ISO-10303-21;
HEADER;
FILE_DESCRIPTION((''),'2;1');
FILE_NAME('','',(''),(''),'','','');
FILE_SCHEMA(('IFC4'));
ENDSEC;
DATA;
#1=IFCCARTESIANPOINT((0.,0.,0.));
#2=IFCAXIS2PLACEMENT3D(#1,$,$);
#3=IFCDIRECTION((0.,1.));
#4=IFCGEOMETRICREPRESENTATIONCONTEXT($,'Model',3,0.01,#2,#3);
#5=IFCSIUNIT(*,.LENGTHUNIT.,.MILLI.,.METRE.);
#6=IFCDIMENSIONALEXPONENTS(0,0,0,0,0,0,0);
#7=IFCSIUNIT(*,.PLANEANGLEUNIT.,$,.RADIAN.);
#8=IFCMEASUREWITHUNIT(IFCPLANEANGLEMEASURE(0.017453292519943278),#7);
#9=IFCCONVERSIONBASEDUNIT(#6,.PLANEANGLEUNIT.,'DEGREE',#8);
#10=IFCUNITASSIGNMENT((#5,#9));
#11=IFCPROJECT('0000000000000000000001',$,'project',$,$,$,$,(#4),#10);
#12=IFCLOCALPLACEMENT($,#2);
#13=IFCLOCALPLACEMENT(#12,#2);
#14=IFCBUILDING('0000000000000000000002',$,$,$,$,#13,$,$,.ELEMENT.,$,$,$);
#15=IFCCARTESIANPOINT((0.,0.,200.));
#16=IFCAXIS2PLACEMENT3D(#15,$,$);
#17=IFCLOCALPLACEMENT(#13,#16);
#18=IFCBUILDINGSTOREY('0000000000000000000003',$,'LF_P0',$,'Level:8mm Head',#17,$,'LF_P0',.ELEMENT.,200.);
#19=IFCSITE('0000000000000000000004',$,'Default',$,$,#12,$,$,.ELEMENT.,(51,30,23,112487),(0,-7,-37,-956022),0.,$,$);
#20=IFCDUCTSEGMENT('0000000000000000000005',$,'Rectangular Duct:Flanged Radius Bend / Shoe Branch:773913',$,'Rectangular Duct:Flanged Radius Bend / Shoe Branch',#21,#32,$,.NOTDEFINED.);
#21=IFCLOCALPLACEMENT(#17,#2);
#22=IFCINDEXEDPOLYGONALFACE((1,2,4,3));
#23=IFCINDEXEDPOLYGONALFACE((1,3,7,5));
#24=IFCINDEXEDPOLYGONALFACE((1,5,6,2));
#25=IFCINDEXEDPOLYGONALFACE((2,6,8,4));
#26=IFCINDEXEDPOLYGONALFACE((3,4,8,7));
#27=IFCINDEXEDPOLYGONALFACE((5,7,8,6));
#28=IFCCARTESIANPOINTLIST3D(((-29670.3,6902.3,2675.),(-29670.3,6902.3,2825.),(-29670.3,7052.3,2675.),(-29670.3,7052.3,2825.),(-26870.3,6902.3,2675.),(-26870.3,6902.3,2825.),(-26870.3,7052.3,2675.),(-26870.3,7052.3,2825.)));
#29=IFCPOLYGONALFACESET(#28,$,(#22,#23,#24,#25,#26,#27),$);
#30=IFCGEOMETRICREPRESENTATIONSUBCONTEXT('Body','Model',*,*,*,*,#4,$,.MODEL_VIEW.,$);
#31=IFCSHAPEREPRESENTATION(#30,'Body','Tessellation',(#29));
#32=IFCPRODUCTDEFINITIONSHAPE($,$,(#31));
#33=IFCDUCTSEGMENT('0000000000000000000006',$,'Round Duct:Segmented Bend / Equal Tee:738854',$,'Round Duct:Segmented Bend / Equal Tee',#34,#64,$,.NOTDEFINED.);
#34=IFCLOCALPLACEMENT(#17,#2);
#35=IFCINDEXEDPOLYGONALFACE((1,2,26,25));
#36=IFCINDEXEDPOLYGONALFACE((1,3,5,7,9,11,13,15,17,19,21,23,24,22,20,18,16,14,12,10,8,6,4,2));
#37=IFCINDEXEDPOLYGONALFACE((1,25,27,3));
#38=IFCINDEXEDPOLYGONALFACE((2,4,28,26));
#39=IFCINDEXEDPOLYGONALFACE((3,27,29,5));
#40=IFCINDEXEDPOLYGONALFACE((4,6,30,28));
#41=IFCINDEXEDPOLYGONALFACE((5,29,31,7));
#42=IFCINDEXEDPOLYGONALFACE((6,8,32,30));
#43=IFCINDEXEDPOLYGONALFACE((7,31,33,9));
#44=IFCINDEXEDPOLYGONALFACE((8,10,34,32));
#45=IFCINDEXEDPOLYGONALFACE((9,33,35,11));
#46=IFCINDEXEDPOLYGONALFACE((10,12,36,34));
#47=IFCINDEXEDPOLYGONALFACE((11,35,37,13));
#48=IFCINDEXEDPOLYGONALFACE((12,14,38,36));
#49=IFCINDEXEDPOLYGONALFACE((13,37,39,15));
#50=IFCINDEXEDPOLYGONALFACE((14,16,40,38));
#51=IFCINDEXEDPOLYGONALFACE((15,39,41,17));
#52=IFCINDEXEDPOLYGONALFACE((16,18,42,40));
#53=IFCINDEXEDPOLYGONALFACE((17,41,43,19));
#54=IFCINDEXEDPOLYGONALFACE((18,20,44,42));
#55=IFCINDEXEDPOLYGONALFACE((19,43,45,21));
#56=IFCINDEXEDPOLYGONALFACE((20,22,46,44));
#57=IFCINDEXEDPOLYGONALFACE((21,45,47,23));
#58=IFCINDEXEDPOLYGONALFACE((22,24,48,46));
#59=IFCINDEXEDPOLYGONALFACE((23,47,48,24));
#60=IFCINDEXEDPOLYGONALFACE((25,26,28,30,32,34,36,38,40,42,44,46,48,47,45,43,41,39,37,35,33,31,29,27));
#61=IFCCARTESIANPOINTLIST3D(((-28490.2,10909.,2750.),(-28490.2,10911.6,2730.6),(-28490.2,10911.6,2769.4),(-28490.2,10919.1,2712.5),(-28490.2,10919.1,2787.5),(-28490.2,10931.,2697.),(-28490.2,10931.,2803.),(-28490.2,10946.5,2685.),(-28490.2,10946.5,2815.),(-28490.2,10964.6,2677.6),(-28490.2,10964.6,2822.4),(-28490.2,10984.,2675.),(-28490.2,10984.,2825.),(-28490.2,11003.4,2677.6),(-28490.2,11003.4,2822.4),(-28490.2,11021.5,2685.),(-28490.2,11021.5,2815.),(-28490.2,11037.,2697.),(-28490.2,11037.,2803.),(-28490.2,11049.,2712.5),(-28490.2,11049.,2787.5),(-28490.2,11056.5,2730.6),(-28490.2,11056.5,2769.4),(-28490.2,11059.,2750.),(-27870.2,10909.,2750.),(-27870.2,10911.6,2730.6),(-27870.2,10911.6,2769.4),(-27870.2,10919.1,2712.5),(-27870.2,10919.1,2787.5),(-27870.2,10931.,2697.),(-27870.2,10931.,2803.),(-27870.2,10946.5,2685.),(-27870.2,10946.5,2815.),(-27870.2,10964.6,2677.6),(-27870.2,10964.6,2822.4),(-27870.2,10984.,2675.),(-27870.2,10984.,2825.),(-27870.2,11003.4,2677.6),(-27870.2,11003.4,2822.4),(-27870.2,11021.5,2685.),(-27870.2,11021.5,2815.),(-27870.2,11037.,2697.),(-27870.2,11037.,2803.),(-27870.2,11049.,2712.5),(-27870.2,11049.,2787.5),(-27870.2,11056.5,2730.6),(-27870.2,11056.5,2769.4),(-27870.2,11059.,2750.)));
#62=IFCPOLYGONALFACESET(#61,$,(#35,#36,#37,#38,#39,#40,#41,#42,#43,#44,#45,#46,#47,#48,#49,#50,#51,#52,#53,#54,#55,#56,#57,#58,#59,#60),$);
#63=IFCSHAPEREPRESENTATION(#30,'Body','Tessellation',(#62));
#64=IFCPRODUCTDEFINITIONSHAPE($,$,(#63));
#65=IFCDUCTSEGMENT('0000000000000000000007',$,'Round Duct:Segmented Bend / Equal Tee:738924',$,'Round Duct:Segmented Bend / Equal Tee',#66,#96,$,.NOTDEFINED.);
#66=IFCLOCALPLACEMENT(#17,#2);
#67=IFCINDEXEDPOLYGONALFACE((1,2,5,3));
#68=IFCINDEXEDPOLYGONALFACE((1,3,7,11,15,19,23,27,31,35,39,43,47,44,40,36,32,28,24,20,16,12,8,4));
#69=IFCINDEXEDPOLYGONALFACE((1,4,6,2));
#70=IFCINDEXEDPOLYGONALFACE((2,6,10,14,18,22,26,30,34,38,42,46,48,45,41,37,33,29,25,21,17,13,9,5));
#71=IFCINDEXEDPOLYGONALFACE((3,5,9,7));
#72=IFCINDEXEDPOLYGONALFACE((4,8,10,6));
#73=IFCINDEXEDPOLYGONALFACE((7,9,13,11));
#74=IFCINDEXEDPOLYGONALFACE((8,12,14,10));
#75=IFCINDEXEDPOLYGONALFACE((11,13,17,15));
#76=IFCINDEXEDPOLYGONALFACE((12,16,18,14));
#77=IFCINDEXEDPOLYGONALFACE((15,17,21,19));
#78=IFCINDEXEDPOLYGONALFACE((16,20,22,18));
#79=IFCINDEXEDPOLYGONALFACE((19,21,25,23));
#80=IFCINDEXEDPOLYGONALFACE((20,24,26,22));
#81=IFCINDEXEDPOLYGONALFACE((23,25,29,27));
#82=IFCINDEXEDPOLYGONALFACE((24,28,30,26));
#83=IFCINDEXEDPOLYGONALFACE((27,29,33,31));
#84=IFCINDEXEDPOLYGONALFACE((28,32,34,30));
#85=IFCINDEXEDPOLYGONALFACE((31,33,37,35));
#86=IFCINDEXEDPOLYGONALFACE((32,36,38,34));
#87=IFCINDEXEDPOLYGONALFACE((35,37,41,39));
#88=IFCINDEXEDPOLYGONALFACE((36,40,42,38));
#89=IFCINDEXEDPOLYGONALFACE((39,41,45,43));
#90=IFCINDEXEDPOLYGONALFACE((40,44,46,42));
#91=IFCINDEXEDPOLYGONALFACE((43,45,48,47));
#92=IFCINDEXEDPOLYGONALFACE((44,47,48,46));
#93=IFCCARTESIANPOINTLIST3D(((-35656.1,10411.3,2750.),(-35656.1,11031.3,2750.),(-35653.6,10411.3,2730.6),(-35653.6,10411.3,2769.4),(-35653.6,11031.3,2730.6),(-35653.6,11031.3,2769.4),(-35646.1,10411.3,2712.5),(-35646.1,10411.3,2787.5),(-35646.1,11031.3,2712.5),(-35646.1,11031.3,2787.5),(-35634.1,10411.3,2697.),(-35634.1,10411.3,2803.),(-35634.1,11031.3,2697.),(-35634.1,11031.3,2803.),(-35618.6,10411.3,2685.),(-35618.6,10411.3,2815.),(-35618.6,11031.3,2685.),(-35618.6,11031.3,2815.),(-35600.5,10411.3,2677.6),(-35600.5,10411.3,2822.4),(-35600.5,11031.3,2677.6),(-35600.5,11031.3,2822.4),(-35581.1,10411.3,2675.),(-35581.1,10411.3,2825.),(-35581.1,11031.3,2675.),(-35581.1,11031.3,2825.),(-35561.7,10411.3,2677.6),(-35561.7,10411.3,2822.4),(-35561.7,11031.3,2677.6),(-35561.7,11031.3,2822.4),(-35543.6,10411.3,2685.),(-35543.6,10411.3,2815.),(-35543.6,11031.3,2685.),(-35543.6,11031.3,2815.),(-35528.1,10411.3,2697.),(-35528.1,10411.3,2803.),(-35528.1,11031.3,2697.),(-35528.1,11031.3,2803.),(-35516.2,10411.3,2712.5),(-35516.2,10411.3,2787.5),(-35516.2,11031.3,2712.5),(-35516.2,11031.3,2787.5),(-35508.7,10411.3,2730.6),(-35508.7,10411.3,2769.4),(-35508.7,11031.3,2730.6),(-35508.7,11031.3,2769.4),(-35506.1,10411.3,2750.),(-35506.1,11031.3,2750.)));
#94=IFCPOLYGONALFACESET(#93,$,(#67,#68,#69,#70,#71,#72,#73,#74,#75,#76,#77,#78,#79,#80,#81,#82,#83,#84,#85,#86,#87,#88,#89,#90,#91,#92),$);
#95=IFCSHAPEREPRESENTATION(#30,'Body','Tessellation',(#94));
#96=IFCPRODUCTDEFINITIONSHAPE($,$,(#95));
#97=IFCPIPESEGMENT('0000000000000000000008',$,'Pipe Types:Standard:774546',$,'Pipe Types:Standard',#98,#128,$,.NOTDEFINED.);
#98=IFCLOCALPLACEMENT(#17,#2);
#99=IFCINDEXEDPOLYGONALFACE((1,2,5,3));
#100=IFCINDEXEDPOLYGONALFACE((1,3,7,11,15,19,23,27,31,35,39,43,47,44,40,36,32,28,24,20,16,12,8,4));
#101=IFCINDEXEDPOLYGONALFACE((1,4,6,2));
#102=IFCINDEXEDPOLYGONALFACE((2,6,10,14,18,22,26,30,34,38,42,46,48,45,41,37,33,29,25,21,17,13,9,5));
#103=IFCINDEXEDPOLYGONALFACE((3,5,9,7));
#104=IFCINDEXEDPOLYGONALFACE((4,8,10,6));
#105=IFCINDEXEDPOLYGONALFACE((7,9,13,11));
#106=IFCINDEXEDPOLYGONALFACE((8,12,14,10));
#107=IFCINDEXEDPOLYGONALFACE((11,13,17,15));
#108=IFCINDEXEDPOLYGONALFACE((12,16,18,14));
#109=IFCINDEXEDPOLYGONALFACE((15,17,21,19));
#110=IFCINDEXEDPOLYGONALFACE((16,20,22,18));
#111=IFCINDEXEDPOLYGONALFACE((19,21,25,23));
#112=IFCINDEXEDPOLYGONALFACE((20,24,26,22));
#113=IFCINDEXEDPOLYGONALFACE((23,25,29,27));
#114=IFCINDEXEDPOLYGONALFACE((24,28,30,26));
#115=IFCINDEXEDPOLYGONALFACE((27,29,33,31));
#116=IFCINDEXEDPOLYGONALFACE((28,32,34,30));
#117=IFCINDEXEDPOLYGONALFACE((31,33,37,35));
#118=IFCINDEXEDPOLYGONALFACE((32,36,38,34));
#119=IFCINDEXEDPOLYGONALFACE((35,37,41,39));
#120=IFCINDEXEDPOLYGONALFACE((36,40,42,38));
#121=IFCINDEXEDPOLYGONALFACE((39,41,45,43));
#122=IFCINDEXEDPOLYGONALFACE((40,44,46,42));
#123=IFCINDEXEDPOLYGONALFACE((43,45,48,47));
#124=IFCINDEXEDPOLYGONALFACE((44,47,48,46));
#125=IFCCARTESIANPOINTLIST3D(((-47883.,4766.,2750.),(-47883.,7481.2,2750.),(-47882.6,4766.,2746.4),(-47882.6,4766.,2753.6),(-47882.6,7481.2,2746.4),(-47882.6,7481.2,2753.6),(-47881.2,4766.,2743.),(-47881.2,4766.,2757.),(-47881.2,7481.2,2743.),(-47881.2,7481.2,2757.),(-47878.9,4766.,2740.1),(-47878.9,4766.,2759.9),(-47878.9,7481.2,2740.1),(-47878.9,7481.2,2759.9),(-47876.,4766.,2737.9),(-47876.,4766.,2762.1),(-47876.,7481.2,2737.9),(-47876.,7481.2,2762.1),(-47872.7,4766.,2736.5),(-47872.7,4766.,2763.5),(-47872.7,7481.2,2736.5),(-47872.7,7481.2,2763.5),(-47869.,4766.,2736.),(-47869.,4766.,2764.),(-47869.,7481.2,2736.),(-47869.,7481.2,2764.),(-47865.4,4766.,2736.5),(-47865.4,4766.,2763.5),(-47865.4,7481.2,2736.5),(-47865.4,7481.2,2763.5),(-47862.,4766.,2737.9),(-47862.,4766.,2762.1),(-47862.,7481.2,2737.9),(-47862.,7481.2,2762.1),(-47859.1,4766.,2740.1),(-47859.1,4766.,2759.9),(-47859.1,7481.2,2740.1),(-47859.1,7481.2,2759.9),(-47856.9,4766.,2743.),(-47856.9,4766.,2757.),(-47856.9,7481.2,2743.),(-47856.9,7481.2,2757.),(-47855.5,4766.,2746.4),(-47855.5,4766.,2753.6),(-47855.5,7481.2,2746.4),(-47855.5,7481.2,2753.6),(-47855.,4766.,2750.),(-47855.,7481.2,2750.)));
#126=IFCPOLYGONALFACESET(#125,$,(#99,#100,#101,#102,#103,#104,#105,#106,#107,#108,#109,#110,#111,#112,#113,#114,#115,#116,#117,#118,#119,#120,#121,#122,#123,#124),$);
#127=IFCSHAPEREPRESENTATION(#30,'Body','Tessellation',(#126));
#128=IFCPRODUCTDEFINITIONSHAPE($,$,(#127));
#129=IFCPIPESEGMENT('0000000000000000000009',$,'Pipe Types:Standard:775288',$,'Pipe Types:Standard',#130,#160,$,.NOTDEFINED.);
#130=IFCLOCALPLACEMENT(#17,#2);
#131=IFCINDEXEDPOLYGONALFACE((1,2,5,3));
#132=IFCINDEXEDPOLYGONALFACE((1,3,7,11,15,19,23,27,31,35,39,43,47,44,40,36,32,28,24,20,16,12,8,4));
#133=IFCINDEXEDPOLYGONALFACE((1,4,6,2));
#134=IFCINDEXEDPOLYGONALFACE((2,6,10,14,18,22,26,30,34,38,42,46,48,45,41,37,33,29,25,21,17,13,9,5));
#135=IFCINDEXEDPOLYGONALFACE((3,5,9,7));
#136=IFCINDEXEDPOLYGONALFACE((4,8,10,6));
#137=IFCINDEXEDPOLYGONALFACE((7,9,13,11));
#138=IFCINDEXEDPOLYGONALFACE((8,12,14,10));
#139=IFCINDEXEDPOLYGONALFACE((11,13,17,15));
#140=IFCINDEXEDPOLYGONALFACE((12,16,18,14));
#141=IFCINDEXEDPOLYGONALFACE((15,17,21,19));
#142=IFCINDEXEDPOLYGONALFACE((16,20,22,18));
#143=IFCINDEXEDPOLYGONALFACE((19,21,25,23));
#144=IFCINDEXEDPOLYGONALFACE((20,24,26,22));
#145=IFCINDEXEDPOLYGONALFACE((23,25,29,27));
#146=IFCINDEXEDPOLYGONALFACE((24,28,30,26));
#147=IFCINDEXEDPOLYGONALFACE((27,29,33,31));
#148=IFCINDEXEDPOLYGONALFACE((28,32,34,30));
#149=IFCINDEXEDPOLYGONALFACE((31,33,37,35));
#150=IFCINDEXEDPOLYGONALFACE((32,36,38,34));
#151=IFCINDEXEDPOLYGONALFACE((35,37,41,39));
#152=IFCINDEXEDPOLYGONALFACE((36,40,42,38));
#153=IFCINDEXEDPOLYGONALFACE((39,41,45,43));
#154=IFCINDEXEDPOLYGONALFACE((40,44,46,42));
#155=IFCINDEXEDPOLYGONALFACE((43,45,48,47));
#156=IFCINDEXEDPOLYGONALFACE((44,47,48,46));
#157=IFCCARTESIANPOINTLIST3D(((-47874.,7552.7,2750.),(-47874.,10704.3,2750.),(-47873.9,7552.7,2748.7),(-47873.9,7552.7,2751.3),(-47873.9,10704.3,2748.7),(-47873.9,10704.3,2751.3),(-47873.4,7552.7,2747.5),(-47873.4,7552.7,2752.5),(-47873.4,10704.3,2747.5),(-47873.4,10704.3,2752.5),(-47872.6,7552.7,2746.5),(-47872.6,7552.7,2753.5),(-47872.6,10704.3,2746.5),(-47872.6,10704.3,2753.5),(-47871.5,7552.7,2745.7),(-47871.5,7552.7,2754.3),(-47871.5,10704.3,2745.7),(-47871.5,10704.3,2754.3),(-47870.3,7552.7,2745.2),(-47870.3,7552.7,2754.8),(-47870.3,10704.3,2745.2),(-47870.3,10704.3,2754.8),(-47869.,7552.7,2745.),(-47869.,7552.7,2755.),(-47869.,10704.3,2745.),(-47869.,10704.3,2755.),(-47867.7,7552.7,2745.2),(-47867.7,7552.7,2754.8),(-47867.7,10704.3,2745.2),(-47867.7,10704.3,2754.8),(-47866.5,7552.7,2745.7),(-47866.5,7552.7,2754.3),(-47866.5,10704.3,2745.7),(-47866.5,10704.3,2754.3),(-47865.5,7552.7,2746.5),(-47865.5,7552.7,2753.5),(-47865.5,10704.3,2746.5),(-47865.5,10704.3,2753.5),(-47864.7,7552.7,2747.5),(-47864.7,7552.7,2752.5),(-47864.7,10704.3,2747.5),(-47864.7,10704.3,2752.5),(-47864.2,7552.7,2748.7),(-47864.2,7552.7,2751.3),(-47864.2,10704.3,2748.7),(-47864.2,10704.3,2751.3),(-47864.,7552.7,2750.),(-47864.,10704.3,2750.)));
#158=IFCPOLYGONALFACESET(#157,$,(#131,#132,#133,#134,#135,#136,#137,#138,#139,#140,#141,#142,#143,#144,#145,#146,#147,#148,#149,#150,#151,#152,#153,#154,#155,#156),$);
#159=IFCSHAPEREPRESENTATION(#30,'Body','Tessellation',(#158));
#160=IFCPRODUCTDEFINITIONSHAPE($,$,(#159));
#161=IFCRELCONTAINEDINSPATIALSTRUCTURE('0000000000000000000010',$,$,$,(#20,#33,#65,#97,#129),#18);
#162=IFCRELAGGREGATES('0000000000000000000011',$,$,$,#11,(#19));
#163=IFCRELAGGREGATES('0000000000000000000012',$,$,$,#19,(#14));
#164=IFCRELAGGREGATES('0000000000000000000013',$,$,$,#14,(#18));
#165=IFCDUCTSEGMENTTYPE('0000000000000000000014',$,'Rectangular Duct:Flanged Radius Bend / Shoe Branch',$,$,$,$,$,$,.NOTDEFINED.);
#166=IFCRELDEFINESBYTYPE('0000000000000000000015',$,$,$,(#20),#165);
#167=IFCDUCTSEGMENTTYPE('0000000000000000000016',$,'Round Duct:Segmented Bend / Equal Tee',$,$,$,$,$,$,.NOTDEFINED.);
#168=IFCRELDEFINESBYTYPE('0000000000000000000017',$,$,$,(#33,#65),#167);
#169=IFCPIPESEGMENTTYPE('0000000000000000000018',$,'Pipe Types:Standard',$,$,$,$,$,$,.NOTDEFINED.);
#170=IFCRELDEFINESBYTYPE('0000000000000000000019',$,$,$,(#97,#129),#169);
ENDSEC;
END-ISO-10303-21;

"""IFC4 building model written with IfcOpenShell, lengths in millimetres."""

from ifc_helpers import new_model, entity, si_unit, converted_unit, direction, frame, origin, place, context, subcontext, project, spatial, arc, indexed_curve, outline, extrude, type_object, element, save


model = new_model("IFC4")

# Units and contexts
model_context = context("Model", 3, precision=0.01, world=origin(), true_north=direction((0.0, 1.0)))
body_context = subcontext(model_context, "Body", "Model", "MODEL_VIEW")
ifc_project = project(units=[si_unit("LENGTHUNIT", "METRE", prefix="MILLI"), converted_unit("PLANEANGLEUNIT", "DEGREE", entity("IfcPlaneAngleMeasure", 0.017453292519943278), si_unit("PLANEANGLEUNIT", "RADIAN"), dimensions=[0, 0, 0, 0, 0, 0, 0])], contexts=[model_context])

# Site, building, storey
site_placement = place(None, origin())
site = spatial("IfcSite", under=ifc_project, at=site_placement, Name="Default", CompositionType="ELEMENT", RefLatitude=(51, 30, 23, 112487), RefLongitude=(0, -7, -37, -956022), RefElevation=0.0)
building_placement = place(site_placement, origin())
building = spatial("IfcBuilding", under=site, at=building_placement, CompositionType="ELEMENT")
storey_placement = place(building_placement, frame((0.0, 0.0, 200.0)))
storey = spatial("IfcBuildingStorey", under=building, at=storey_placement, Name="LF_P0", ObjectType="Level:8mm Head", LongName="LF_P0", CompositionType="ELEMENT", Elevation=200.0)

# Duct segments
duct_segment_type_1 = type_object("IfcDuctSegmentType", Name="Rectangular Duct:Flanged Radius Bend / Shoe Branch", PredefinedType="NOTDEFINED")
duct_segment_1_placement = place(storey_placement, origin())
element("IfcDuctSegment", 1, at=duct_segment_1_placement, inside=storey, type_object=duct_segment_type_1, Name="Rectangular Duct:Flanged Radius Bend / Shoe Branch:773913", ObjectType="Rectangular Duct:Flanged Radius Bend / Shoe Branch", PredefinedType="NOTDEFINED", context=body_context, shape_type="SweptSolid", body=[
    extrude(outline(indexed_curve([(-1400.0, -75.0), (1400.0, -75.0), (1400.0, 75.0), (-1400.0, 75.0), (-1400.0, -75.0)], self_intersect=False)), frame((-28270.3, 6977.3, 2675.0), z_axis=(0.0, 0.0, 1.0), x_axis=(-1.0, 0.0, 0.0)), (0.0, 0.0, 1.0), 150.0),
])
duct_segment_type_2 = type_object("IfcDuctSegmentType", Name="Round Duct:Segmented Bend / Equal Tee", PredefinedType="NOTDEFINED")
duct_segment_2_placement = place(storey_placement, origin())
element("IfcDuctSegment", 2, at=duct_segment_2_placement, inside=storey, type_object=duct_segment_type_2, Name="Round Duct:Segmented Bend / Equal Tee:738854", ObjectType="Round Duct:Segmented Bend / Equal Tee", PredefinedType="NOTDEFINED", context=body_context, shape_type="SweptSolid", body=[
    extrude(outline(indexed_curve([(75.0, 0.0), (53.0, 53.0), (0.0, 75.0), (-53.0, 53.0), (-75.0, 0.0), (-53.0, -53.0), (0.0, -75.0), (53.0, -53.0)], segments=[arc(1, 2, 3), arc(3, 4, 5), arc(5, 6, 7), arc(7, 8, 1)], self_intersect=False)), frame((-28490.2, 10984.0, 2750.0), z_axis=(1.0, 0.0, 0.0), x_axis=(0.0, -1.0, 0.0)), (0.0, 0.0, 1.0), 620.0),
])
duct_segment_3_placement = place(storey_placement, origin())
element("IfcDuctSegment", 3, at=duct_segment_3_placement, inside=storey, type_object=duct_segment_type_2, Name="Round Duct:Segmented Bend / Equal Tee:738924", ObjectType="Round Duct:Segmented Bend / Equal Tee", PredefinedType="NOTDEFINED", context=body_context, shape_type="SweptSolid", body=[
    extrude(outline(indexed_curve([(75.0, 0.0), (53.0, 53.0), (0.0, 75.0), (-53.0, 53.0), (-75.0, 0.0), (-53.0, -53.0), (0.0, -75.0), (53.0, -53.0)], segments=[arc(1, 2, 3), arc(3, 4, 5), arc(5, 6, 7), arc(7, 8, 1)], self_intersect=False)), frame((-35581.1, 10411.3, 2750.0), z_axis=(0.0, 1.0, 0.0), x_axis=(1.0, 0.0, 0.0)), (0.0, 0.0, 1.0), 620.0),
])

# Pipe segments
pipe_segment_type = type_object("IfcPipeSegmentType", Name="Pipe Types:Standard", PredefinedType="NOTDEFINED")
pipe_segment_1_placement = place(storey_placement, origin())
element("IfcPipeSegment", 4, at=pipe_segment_1_placement, inside=storey, type_object=pipe_segment_type, Name="Pipe Types:Standard:774546", ObjectType="Pipe Types:Standard", PredefinedType="NOTDEFINED", context=body_context, shape_type="SweptSolid", body=[
    extrude(outline(indexed_curve([(14.0, 0.0), (9.9, 9.9), (0.0, 14.0), (-9.9, 9.9), (-14.0, 0.0), (-9.9, -9.9), (0.0, -14.0), (9.9, -9.9)], segments=[arc(1, 2, 3), arc(3, 4, 5), arc(5, 6, 7), arc(7, 8, 1)], self_intersect=False)), frame((-47869.0, 4766.0, 2750.0), z_axis=(0.0, 1.0, 0.0), x_axis=(1.0, 0.0, 0.0)), (0.0, 0.0, 1.0), 2715.2),
])
pipe_segment_2_placement = place(storey_placement, origin())
element("IfcPipeSegment", 5, at=pipe_segment_2_placement, inside=storey, type_object=pipe_segment_type, Name="Pipe Types:Standard:775288", ObjectType="Pipe Types:Standard", PredefinedType="NOTDEFINED", context=body_context, shape_type="SweptSolid", body=[
    extrude(outline(indexed_curve([(5.0, 0.0), (3.5, 3.5), (0.0, 5.0), (-3.5, 3.5), (-5.0, 0.0), (-3.5, -3.5), (0.0, -5.0), (3.5, -3.5)], segments=[arc(1, 2, 3), arc(3, 4, 5), arc(5, 6, 7), arc(7, 8, 1)], self_intersect=False)), frame((-47869.0, 7552.7, 2750.0), z_axis=(0.0, 1.0, 0.0), x_axis=(-1.0, 0.0, 0.0)), (0.0, 0.0, 1.0), 3151.6),
])

save(model, "model.ifc")
